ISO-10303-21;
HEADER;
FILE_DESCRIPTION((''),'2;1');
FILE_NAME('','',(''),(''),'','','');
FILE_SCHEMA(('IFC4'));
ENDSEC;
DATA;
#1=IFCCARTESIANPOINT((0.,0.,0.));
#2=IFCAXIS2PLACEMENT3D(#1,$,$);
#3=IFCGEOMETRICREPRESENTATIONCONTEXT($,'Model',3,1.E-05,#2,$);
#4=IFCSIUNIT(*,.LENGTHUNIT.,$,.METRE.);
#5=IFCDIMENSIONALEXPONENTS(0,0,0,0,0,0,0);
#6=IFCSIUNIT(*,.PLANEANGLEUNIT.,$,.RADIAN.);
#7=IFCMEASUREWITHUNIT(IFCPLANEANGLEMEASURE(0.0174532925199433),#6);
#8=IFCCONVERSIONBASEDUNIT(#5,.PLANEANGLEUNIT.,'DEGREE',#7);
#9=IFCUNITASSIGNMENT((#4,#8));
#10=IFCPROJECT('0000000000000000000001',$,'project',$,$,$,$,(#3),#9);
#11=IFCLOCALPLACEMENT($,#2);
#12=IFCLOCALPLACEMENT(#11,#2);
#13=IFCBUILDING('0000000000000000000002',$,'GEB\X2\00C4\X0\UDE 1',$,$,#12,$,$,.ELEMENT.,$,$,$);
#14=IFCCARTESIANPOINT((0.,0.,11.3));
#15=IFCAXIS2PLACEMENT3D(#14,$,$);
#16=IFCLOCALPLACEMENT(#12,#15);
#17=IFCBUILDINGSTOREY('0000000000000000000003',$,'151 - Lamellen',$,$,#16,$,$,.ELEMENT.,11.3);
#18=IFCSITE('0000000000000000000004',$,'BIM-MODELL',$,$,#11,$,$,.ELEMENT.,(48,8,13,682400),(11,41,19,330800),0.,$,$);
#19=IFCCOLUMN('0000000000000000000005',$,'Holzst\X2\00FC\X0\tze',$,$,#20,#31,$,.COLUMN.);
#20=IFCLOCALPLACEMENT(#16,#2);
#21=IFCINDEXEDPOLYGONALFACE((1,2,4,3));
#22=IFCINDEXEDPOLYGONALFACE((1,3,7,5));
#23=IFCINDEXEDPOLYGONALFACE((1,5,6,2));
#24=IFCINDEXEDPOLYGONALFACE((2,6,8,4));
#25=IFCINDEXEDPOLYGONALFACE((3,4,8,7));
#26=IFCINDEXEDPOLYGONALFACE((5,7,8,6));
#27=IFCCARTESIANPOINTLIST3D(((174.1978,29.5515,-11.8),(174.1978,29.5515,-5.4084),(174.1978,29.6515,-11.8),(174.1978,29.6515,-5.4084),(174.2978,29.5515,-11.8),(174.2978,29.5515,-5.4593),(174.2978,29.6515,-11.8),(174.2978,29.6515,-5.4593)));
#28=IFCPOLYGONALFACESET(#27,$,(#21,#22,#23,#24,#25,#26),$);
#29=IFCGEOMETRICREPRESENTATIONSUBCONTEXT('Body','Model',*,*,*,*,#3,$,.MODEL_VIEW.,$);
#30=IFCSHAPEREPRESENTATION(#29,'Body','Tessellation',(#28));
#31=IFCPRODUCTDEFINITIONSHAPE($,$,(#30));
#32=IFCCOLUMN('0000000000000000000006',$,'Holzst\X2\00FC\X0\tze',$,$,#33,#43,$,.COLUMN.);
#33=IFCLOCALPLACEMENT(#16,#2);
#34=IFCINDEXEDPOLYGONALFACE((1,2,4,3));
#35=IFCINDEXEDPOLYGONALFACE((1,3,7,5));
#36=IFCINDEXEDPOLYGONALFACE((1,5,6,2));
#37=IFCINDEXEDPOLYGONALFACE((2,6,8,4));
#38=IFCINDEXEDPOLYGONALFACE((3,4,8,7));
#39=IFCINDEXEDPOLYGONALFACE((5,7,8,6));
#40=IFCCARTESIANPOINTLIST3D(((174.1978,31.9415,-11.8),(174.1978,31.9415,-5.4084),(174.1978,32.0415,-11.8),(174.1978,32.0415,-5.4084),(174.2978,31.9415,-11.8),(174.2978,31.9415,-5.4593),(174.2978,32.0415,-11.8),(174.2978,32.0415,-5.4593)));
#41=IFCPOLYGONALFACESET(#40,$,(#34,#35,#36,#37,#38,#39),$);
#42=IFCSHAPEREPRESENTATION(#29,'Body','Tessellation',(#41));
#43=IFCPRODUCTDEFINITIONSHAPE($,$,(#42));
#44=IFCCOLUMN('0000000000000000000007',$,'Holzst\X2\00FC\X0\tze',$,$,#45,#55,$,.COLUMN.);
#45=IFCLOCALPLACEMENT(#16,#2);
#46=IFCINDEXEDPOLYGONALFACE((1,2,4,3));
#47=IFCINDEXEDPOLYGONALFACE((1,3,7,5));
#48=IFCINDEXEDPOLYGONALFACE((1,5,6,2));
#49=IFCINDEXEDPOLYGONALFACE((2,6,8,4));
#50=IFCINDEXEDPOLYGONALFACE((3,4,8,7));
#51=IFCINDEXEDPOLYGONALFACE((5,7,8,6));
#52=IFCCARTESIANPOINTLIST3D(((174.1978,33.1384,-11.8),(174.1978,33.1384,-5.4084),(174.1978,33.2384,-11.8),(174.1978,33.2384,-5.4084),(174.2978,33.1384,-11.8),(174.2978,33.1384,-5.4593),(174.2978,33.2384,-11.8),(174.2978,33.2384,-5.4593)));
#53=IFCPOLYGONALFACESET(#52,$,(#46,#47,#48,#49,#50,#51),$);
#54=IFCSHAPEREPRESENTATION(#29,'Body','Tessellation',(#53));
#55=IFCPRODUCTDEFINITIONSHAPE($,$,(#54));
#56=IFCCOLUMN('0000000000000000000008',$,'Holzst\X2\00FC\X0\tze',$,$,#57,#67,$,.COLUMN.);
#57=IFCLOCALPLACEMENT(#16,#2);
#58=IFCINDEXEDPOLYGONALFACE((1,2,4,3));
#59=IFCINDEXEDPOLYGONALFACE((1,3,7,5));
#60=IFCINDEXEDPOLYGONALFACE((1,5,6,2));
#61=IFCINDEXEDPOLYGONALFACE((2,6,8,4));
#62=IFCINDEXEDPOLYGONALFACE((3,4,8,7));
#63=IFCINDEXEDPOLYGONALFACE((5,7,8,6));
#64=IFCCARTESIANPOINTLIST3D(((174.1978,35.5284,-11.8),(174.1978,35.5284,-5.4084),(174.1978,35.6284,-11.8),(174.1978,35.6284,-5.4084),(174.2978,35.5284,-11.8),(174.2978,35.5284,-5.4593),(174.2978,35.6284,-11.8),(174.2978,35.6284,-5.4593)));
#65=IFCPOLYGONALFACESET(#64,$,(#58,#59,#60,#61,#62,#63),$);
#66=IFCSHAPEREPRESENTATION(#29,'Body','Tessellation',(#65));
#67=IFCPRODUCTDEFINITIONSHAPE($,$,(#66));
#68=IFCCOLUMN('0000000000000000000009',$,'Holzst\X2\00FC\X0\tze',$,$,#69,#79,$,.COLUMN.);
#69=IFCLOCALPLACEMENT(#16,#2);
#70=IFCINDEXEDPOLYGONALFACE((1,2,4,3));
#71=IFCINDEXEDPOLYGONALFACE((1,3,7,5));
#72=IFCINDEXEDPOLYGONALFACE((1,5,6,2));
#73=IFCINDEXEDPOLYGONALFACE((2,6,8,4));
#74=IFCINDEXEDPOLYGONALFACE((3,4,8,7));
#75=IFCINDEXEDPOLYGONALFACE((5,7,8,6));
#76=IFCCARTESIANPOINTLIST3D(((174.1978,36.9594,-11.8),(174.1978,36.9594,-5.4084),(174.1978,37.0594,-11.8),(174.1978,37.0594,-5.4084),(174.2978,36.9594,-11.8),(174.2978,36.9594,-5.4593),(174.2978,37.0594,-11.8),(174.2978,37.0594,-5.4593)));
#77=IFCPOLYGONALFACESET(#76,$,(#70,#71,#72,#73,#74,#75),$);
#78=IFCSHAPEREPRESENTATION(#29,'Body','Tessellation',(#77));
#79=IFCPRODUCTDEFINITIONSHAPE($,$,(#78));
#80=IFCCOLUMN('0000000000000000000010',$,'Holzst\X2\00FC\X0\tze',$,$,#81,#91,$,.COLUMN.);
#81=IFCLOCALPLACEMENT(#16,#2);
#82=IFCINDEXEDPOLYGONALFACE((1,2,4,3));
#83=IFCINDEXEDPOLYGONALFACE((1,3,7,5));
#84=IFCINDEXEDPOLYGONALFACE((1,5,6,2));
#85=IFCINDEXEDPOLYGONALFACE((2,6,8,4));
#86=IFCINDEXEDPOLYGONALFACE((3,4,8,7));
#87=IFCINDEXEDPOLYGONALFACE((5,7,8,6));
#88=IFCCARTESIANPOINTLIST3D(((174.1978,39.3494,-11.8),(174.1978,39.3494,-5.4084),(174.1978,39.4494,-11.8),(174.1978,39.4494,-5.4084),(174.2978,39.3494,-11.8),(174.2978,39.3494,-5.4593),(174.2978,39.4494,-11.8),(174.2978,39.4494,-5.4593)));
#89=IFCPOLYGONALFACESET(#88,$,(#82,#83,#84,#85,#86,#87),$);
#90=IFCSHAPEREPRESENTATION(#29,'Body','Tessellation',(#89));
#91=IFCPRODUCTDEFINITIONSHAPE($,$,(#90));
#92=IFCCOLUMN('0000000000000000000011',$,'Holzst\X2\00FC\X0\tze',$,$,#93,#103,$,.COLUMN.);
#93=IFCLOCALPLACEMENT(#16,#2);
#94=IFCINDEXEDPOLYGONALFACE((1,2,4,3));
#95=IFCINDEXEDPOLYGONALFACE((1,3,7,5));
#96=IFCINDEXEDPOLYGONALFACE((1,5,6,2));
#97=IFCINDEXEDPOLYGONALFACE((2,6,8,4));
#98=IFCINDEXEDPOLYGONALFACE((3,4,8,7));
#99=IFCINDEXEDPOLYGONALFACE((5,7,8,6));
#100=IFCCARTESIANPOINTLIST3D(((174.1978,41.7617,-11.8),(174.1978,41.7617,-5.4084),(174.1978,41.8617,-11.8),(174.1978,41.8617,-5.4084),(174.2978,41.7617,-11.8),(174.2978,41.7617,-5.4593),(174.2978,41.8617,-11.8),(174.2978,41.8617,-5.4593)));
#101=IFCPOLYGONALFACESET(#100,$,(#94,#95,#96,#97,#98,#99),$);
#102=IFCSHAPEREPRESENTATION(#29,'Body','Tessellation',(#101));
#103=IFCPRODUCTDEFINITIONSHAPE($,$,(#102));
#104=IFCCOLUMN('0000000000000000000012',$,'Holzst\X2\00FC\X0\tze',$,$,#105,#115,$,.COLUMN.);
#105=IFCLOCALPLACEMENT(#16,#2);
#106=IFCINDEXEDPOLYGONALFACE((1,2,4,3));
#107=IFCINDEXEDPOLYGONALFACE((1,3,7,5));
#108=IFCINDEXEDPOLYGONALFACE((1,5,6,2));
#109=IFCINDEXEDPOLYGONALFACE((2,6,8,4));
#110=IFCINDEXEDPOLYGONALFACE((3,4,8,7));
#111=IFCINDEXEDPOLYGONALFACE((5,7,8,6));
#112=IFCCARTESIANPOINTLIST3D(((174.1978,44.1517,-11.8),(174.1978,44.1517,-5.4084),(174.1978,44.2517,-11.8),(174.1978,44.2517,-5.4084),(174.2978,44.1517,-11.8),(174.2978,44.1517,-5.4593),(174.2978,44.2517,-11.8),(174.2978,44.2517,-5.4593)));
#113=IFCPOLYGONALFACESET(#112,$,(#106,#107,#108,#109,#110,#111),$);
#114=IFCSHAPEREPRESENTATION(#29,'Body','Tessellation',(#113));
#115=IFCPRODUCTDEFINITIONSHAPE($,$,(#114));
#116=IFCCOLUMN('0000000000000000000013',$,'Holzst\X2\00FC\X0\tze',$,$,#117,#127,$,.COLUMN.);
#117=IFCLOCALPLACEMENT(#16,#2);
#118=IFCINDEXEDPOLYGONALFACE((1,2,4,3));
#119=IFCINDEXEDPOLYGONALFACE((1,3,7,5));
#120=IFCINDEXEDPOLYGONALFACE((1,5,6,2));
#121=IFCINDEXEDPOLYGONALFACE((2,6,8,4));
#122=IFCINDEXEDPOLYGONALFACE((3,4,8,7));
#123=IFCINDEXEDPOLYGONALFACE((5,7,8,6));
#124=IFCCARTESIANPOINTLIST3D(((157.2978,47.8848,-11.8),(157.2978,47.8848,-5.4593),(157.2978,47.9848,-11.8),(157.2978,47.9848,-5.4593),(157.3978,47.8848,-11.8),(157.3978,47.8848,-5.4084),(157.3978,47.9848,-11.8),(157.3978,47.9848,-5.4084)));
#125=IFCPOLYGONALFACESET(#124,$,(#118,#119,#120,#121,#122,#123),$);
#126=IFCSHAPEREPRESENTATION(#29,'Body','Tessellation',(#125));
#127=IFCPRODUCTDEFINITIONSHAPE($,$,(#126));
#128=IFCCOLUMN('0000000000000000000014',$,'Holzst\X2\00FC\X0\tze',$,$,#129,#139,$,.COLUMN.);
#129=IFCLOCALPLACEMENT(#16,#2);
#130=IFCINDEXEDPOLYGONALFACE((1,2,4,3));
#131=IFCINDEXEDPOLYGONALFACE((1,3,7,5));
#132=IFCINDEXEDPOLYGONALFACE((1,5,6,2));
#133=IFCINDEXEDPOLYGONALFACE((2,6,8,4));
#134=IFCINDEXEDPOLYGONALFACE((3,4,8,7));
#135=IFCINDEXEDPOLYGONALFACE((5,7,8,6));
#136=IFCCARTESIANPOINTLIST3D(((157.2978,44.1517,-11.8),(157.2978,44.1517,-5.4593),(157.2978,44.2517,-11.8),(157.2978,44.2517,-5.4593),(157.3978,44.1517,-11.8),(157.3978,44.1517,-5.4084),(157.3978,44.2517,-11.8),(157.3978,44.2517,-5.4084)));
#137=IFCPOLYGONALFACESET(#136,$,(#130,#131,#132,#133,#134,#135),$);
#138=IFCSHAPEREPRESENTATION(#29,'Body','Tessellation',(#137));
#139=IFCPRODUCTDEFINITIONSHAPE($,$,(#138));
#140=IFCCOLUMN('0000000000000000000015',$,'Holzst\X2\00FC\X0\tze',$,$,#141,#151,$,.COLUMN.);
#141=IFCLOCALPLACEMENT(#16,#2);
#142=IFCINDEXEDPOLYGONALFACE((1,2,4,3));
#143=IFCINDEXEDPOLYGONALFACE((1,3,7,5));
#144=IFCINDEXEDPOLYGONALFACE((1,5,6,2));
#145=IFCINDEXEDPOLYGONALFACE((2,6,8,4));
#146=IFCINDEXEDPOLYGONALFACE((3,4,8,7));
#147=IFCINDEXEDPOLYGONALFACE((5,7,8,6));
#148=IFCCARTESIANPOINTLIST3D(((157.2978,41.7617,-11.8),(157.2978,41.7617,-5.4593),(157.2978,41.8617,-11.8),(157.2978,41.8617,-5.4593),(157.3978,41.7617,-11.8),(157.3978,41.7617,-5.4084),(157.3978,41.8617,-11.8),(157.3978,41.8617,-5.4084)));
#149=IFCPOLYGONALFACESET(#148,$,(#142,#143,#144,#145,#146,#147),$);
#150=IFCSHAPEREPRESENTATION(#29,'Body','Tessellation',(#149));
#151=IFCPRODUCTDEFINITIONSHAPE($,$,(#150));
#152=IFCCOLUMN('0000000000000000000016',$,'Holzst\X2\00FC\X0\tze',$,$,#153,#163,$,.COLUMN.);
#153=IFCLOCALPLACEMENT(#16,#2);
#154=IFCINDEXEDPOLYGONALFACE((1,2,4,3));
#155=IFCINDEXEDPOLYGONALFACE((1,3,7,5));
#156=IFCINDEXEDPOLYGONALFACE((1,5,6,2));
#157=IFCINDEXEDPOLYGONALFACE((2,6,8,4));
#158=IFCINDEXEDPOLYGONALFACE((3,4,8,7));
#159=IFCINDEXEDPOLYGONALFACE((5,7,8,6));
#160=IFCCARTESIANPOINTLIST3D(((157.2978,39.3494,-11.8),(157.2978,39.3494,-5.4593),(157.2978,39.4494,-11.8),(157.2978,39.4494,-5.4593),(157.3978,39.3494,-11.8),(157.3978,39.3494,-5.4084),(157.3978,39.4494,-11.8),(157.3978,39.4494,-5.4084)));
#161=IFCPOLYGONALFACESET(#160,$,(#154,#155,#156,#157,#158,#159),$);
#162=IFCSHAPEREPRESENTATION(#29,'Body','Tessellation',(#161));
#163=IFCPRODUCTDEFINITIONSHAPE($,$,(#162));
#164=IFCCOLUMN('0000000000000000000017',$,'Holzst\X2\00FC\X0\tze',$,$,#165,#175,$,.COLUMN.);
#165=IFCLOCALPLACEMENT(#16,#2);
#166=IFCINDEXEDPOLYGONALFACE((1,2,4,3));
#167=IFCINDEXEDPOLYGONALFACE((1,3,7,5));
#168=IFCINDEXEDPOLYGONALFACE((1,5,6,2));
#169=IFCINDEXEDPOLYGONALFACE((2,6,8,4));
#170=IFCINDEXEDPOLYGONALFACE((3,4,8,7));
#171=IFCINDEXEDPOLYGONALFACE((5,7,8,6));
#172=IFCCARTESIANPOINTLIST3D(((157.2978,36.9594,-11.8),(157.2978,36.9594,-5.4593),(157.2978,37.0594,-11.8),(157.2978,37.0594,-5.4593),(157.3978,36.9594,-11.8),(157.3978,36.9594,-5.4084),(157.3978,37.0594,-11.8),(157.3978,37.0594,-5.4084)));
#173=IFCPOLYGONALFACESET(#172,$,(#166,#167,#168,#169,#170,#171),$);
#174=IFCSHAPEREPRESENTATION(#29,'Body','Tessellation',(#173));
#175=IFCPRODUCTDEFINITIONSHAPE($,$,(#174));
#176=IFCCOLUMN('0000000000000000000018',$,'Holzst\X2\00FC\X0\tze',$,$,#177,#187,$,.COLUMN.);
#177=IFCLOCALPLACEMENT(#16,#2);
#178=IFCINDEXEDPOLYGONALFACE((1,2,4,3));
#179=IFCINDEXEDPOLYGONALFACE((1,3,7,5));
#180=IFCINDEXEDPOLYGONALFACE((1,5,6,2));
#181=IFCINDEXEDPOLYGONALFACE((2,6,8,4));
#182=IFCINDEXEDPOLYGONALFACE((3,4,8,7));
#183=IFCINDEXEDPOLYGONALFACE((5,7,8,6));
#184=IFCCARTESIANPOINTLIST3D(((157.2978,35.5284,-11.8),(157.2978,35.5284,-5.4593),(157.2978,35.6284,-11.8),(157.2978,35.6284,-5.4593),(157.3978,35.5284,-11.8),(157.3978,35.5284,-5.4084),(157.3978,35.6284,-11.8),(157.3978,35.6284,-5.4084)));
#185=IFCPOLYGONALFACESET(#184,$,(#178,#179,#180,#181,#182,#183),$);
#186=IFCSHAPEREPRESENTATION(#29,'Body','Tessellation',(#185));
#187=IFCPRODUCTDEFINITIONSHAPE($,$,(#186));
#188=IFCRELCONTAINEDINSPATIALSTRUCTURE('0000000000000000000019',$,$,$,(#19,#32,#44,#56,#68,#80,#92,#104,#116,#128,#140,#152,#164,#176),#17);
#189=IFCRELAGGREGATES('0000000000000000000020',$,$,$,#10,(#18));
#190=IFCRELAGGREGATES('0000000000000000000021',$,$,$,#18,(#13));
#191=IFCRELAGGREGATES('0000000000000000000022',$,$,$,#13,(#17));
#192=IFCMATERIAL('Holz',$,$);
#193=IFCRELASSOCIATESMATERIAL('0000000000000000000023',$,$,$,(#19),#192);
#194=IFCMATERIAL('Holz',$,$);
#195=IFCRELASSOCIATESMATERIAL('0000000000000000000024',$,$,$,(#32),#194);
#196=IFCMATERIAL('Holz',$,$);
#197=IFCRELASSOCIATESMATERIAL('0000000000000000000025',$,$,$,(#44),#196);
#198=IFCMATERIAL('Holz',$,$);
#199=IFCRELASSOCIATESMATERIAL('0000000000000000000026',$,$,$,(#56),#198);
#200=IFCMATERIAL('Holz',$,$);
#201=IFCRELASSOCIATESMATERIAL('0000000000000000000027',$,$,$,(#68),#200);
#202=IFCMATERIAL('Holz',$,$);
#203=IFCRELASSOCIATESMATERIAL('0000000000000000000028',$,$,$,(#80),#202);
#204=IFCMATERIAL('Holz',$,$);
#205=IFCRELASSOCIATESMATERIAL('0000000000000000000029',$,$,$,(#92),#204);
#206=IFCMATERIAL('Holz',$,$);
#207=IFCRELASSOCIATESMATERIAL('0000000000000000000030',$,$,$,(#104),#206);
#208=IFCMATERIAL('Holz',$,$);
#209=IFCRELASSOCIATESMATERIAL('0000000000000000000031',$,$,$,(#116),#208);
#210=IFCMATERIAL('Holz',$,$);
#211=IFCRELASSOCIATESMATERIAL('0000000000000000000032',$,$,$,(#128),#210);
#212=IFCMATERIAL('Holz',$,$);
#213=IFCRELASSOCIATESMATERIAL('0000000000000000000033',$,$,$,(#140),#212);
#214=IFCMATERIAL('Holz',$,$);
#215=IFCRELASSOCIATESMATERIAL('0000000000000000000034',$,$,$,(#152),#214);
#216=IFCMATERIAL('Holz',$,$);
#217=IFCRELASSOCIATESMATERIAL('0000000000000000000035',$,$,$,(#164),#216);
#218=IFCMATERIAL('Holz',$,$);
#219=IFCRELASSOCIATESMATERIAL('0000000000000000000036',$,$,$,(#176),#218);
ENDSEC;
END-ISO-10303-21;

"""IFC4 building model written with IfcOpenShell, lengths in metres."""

from ifc_helpers import new_model, entity, si_unit, converted_unit, frame, frame_2d, origin, origin_with_axes, place, context, subcontext, project, spatial, rectangle, extrude, clip, halfspace, material, element, save


model = new_model("IFC4")

# Units and contexts
model_context = context("Model", 3, precision=1e-05, world=origin())
body_context = subcontext(model_context, "Body", "Model", "MODEL_VIEW")
ifc_project = project(units=[si_unit("LENGTHUNIT", "METRE"), converted_unit("PLANEANGLEUNIT", "DEGREE", entity("IfcPlaneAngleMeasure", 0.0174532925199433), si_unit("PLANEANGLEUNIT", "RADIAN"), dimensions=[0, 0, 0, 0, 0, 0, 0])], contexts=[model_context])

# Site, building, storey
site_placement = place(None, origin())
site = spatial("IfcSite", under=ifc_project, at=site_placement, Name="BIM-MODELL", CompositionType="ELEMENT", RefLatitude=(48, 8, 13, 682400), RefLongitude=(11, 41, 19, 330800), RefElevation=0.0)
building_placement = place(site_placement, origin())
building = spatial("IfcBuilding", under=site, at=building_placement, Name="GEBÄUDE 1", CompositionType="ELEMENT")
storey_placement = place(building_placement, frame((0.0, 0.0, 11.3)))
storey = spatial("IfcBuildingStorey", under=building, at=storey_placement, Name="151 - Lamellen", CompositionType="ELEMENT", Elevation=11.3)

# Columns
ifc_material_1 = material(Name="Holz")
column_1_placement = place(storey_placement, frame((174.2978, 29.5515, -11.8)))
element("IfcColumn", 1, at=column_1_placement, inside=storey, material=ifc_material_1, Name="Holzstütze", PredefinedType="COLUMN", context=body_context, shape_type="Clipping", body=[
    clip(extrude(rectangle(XDim=0.1, YDim=0.1, at=frame_2d((-0.05, 0.05), x_axis=(0.0, 1.0))), origin_with_axes(), (0.0, 0.0, 1.0), 6.3916), halfspace(frame((-0.05, 0.05, 6.3661), z_axis=(-0.45399, 0.0, -0.891007), x_axis=(0.891007, 0.0, -0.45399)), True)),
])
ifc_material_2 = material(Name="Holz")
column_2_placement = place(storey_placement, frame((174.2978, 31.9415, -11.8)))
element("IfcColumn", 2, at=column_2_placement, inside=storey, material=ifc_material_2, Name="Holzstütze", PredefinedType="COLUMN", context=body_context, shape_type="Clipping", body=[
    clip(extrude(rectangle(XDim=0.1, YDim=0.1, at=frame_2d((-0.05, 0.05), x_axis=(0.0, 1.0))), origin_with_axes(), (0.0, 0.0, 1.0), 6.3916), halfspace(frame((-0.05, 0.05, 6.3661), z_axis=(-0.45399, 0.0, -0.891007), x_axis=(0.891007, 0.0, -0.45399)), True)),
])
ifc_material_3 = material(Name="Holz")
column_3_placement = place(storey_placement, frame((174.2978, 33.1384, -11.8)))
element("IfcColumn", 3, at=column_3_placement, inside=storey, material=ifc_material_3, Name="Holzstütze", PredefinedType="COLUMN", context=body_context, shape_type="Clipping", body=[
    clip(extrude(rectangle(XDim=0.1, YDim=0.1, at=frame_2d((-0.05, 0.05), x_axis=(0.0, 1.0))), origin_with_axes(), (0.0, 0.0, 1.0), 6.3916), halfspace(frame((-0.05, 0.05, 6.3661), z_axis=(-0.45399, 0.0, -0.891007), x_axis=(0.891007, 0.0, -0.45399)), True)),
])
ifc_material_4 = material(Name="Holz")
column_4_placement = place(storey_placement, frame((174.2978, 35.5284, -11.8)))
element("IfcColumn", 4, at=column_4_placement, inside=storey, material=ifc_material_4, Name="Holzstütze", PredefinedType="COLUMN", context=body_context, shape_type="Clipping", body=[
    clip(extrude(rectangle(XDim=0.1, YDim=0.1, at=frame_2d((-0.05, 0.05), x_axis=(0.0, 1.0))), origin_with_axes(), (0.0, 0.0, 1.0), 6.3916), halfspace(frame((-0.05, 0.05, 6.3661), z_axis=(-0.45399, 0.0, -0.891007), x_axis=(0.891007, 0.0, -0.45399)), True)),
])
ifc_material_5 = material(Name="Holz")
column_5_placement = place(storey_placement, frame((174.2978, 36.9594, -11.8)))
element("IfcColumn", 5, at=column_5_placement, inside=storey, material=ifc_material_5, Name="Holzstütze", PredefinedType="COLUMN", context=body_context, shape_type="Clipping", body=[
    clip(extrude(rectangle(XDim=0.1, YDim=0.1, at=frame_2d((-0.05, 0.05), x_axis=(0.0, 1.0))), origin_with_axes(), (0.0, 0.0, 1.0), 6.3916), halfspace(frame((-0.05, 0.05, 6.3661), z_axis=(-0.45399, 0.0, -0.891007), x_axis=(0.891007, 0.0, -0.45399)), True)),
])
ifc_material_6 = material(Name="Holz")
column_6_placement = place(storey_placement, frame((174.2978, 39.3494, -11.8)))
element("IfcColumn", 6, at=column_6_placement, inside=storey, material=ifc_material_6, Name="Holzstütze", PredefinedType="COLUMN", context=body_context, shape_type="Clipping", body=[
    clip(extrude(rectangle(XDim=0.1, YDim=0.1, at=frame_2d((-0.05, 0.05), x_axis=(0.0, 1.0))), origin_with_axes(), (0.0, 0.0, 1.0), 6.3916), halfspace(frame((-0.05, 0.05, 6.3661), z_axis=(-0.45399, 0.0, -0.891007), x_axis=(0.891007, 0.0, -0.45399)), True)),
])
ifc_material_7 = material(Name="Holz")
column_7_placement = place(storey_placement, frame((174.2978, 41.7617, -11.8)))
element("IfcColumn", 7, at=column_7_placement, inside=storey, material=ifc_material_7, Name="Holzstütze", PredefinedType="COLUMN", context=body_context, shape_type="Clipping", body=[
    clip(extrude(rectangle(XDim=0.1, YDim=0.1, at=frame_2d((-0.05, 0.05), x_axis=(0.0, 1.0))), origin_with_axes(), (0.0, 0.0, 1.0), 6.3916), halfspace(frame((-0.05, 0.05, 6.3661), z_axis=(-0.45399, 0.0, -0.891007), x_axis=(0.891007, 0.0, -0.45399)), True)),
])
ifc_material_8 = material(Name="Holz")
column_8_placement = place(storey_placement, frame((174.2978, 44.1517, -11.8)))
element("IfcColumn", 8, at=column_8_placement, inside=storey, material=ifc_material_8, Name="Holzstütze", PredefinedType="COLUMN", context=body_context, shape_type="Clipping", body=[
    clip(extrude(rectangle(XDim=0.1, YDim=0.1, at=frame_2d((-0.05, 0.05), x_axis=(0.0, 1.0))), origin_with_axes(), (0.0, 0.0, 1.0), 6.3916), halfspace(frame((-0.05, 0.05, 6.3661), z_axis=(-0.45399, 0.0, -0.891007), x_axis=(0.891007, 0.0, -0.45399)), True)),
])
ifc_material_9 = material(Name="Holz")
column_9_placement = place(storey_placement, frame((157.3978, 47.8848, -11.8)))
element("IfcColumn", 9, at=column_9_placement, inside=storey, material=ifc_material_9, Name="Holzstütze", PredefinedType="COLUMN", context=body_context, shape_type="Clipping", body=[
    clip(extrude(rectangle(XDim=0.1, YDim=0.1, at=frame_2d((-0.05, 0.05), x_axis=(0.0, 1.0))), origin_with_axes(), (0.0, 0.0, 1.0), 6.3916), halfspace(frame((-0.05, 0.05, 6.3661), z_axis=(0.45399, 0.0, -0.891007), x_axis=(0.0, 1.0, 0.0)), True)),
])
ifc_material_10 = material(Name="Holz")
column_10_placement = place(storey_placement, frame((157.3978, 44.1517, -11.8)))
element("IfcColumn", 10, at=column_10_placement, inside=storey, material=ifc_material_10, Name="Holzstütze", PredefinedType="COLUMN", context=body_context, shape_type="Clipping", body=[
    clip(extrude(rectangle(XDim=0.1, YDim=0.1, at=frame_2d((-0.05, 0.05), x_axis=(0.0, 1.0))), origin_with_axes(), (0.0, 0.0, 1.0), 6.3916), halfspace(frame((-0.05, 0.05, 6.3661), z_axis=(0.45399, 0.0, -0.891007), x_axis=(-0.891007, 0.0, -0.45399)), True)),
])
ifc_material_11 = material(Name="Holz")
column_11_placement = place(storey_placement, frame((157.3978, 41.7617, -11.8)))
element("IfcColumn", 11, at=column_11_placement, inside=storey, material=ifc_material_11, Name="Holzstütze", PredefinedType="COLUMN", context=body_context, shape_type="Clipping", body=[
    clip(extrude(rectangle(XDim=0.1, YDim=0.1, at=frame_2d((-0.05, 0.05), x_axis=(0.0, 1.0))), origin_with_axes(), (0.0, 0.0, 1.0), 6.3916), halfspace(frame((-0.05, 0.05, 6.3661), z_axis=(0.45399, 0.0, -0.891007), x_axis=(-0.891007, 0.0, -0.45399)), True)),
])
ifc_material_12 = material(Name="Holz")
column_12_placement = place(storey_placement, frame((157.3978, 39.3494, -11.8)))
element("IfcColumn", 12, at=column_12_placement, inside=storey, material=ifc_material_12, Name="Holzstütze", PredefinedType="COLUMN", context=body_context, shape_type="Clipping", body=[
    clip(extrude(rectangle(XDim=0.1, YDim=0.1, at=frame_2d((-0.05, 0.05), x_axis=(0.0, 1.0))), origin_with_axes(), (0.0, 0.0, 1.0), 6.3916), halfspace(frame((-0.05, 0.05, 6.3661), z_axis=(0.45399, 0.0, -0.891007), x_axis=(-0.891007, 0.0, -0.45399)), True)),
])
ifc_material_13 = material(Name="Holz")
column_13_placement = place(storey_placement, frame((157.3978, 36.9594, -11.8)))
element("IfcColumn", 13, at=column_13_placement, inside=storey, material=ifc_material_13, Name="Holzstütze", PredefinedType="COLUMN", context=body_context, shape_type="Clipping", body=[
    clip(extrude(rectangle(XDim=0.1, YDim=0.1, at=frame_2d((-0.05, 0.05), x_axis=(0.0, 1.0))), origin_with_axes(), (0.0, 0.0, 1.0), 6.3916), halfspace(frame((-0.05, 0.05, 6.3661), z_axis=(0.45399, 0.0, -0.891007), x_axis=(-0.891007, 0.0, -0.45399)), True)),
])
ifc_material_14 = material(Name="Holz")
column_14_placement = place(storey_placement, frame((157.3978, 35.5284, -11.8)))
element("IfcColumn", 14, at=column_14_placement, inside=storey, material=ifc_material_14, Name="Holzstütze", PredefinedType="COLUMN", context=body_context, shape_type="Clipping", body=[
    clip(extrude(rectangle(XDim=0.1, YDim=0.1, at=frame_2d((-0.05, 0.05), x_axis=(0.0, 1.0))), origin_with_axes(), (0.0, 0.0, 1.0), 6.3916), halfspace(frame((-0.05, 0.05, 6.3661), z_axis=(0.45399, 0.0, -0.891007), x_axis=(-0.891007, 0.0, -0.45399)), True)),
])

save(model, "model.ifc")
